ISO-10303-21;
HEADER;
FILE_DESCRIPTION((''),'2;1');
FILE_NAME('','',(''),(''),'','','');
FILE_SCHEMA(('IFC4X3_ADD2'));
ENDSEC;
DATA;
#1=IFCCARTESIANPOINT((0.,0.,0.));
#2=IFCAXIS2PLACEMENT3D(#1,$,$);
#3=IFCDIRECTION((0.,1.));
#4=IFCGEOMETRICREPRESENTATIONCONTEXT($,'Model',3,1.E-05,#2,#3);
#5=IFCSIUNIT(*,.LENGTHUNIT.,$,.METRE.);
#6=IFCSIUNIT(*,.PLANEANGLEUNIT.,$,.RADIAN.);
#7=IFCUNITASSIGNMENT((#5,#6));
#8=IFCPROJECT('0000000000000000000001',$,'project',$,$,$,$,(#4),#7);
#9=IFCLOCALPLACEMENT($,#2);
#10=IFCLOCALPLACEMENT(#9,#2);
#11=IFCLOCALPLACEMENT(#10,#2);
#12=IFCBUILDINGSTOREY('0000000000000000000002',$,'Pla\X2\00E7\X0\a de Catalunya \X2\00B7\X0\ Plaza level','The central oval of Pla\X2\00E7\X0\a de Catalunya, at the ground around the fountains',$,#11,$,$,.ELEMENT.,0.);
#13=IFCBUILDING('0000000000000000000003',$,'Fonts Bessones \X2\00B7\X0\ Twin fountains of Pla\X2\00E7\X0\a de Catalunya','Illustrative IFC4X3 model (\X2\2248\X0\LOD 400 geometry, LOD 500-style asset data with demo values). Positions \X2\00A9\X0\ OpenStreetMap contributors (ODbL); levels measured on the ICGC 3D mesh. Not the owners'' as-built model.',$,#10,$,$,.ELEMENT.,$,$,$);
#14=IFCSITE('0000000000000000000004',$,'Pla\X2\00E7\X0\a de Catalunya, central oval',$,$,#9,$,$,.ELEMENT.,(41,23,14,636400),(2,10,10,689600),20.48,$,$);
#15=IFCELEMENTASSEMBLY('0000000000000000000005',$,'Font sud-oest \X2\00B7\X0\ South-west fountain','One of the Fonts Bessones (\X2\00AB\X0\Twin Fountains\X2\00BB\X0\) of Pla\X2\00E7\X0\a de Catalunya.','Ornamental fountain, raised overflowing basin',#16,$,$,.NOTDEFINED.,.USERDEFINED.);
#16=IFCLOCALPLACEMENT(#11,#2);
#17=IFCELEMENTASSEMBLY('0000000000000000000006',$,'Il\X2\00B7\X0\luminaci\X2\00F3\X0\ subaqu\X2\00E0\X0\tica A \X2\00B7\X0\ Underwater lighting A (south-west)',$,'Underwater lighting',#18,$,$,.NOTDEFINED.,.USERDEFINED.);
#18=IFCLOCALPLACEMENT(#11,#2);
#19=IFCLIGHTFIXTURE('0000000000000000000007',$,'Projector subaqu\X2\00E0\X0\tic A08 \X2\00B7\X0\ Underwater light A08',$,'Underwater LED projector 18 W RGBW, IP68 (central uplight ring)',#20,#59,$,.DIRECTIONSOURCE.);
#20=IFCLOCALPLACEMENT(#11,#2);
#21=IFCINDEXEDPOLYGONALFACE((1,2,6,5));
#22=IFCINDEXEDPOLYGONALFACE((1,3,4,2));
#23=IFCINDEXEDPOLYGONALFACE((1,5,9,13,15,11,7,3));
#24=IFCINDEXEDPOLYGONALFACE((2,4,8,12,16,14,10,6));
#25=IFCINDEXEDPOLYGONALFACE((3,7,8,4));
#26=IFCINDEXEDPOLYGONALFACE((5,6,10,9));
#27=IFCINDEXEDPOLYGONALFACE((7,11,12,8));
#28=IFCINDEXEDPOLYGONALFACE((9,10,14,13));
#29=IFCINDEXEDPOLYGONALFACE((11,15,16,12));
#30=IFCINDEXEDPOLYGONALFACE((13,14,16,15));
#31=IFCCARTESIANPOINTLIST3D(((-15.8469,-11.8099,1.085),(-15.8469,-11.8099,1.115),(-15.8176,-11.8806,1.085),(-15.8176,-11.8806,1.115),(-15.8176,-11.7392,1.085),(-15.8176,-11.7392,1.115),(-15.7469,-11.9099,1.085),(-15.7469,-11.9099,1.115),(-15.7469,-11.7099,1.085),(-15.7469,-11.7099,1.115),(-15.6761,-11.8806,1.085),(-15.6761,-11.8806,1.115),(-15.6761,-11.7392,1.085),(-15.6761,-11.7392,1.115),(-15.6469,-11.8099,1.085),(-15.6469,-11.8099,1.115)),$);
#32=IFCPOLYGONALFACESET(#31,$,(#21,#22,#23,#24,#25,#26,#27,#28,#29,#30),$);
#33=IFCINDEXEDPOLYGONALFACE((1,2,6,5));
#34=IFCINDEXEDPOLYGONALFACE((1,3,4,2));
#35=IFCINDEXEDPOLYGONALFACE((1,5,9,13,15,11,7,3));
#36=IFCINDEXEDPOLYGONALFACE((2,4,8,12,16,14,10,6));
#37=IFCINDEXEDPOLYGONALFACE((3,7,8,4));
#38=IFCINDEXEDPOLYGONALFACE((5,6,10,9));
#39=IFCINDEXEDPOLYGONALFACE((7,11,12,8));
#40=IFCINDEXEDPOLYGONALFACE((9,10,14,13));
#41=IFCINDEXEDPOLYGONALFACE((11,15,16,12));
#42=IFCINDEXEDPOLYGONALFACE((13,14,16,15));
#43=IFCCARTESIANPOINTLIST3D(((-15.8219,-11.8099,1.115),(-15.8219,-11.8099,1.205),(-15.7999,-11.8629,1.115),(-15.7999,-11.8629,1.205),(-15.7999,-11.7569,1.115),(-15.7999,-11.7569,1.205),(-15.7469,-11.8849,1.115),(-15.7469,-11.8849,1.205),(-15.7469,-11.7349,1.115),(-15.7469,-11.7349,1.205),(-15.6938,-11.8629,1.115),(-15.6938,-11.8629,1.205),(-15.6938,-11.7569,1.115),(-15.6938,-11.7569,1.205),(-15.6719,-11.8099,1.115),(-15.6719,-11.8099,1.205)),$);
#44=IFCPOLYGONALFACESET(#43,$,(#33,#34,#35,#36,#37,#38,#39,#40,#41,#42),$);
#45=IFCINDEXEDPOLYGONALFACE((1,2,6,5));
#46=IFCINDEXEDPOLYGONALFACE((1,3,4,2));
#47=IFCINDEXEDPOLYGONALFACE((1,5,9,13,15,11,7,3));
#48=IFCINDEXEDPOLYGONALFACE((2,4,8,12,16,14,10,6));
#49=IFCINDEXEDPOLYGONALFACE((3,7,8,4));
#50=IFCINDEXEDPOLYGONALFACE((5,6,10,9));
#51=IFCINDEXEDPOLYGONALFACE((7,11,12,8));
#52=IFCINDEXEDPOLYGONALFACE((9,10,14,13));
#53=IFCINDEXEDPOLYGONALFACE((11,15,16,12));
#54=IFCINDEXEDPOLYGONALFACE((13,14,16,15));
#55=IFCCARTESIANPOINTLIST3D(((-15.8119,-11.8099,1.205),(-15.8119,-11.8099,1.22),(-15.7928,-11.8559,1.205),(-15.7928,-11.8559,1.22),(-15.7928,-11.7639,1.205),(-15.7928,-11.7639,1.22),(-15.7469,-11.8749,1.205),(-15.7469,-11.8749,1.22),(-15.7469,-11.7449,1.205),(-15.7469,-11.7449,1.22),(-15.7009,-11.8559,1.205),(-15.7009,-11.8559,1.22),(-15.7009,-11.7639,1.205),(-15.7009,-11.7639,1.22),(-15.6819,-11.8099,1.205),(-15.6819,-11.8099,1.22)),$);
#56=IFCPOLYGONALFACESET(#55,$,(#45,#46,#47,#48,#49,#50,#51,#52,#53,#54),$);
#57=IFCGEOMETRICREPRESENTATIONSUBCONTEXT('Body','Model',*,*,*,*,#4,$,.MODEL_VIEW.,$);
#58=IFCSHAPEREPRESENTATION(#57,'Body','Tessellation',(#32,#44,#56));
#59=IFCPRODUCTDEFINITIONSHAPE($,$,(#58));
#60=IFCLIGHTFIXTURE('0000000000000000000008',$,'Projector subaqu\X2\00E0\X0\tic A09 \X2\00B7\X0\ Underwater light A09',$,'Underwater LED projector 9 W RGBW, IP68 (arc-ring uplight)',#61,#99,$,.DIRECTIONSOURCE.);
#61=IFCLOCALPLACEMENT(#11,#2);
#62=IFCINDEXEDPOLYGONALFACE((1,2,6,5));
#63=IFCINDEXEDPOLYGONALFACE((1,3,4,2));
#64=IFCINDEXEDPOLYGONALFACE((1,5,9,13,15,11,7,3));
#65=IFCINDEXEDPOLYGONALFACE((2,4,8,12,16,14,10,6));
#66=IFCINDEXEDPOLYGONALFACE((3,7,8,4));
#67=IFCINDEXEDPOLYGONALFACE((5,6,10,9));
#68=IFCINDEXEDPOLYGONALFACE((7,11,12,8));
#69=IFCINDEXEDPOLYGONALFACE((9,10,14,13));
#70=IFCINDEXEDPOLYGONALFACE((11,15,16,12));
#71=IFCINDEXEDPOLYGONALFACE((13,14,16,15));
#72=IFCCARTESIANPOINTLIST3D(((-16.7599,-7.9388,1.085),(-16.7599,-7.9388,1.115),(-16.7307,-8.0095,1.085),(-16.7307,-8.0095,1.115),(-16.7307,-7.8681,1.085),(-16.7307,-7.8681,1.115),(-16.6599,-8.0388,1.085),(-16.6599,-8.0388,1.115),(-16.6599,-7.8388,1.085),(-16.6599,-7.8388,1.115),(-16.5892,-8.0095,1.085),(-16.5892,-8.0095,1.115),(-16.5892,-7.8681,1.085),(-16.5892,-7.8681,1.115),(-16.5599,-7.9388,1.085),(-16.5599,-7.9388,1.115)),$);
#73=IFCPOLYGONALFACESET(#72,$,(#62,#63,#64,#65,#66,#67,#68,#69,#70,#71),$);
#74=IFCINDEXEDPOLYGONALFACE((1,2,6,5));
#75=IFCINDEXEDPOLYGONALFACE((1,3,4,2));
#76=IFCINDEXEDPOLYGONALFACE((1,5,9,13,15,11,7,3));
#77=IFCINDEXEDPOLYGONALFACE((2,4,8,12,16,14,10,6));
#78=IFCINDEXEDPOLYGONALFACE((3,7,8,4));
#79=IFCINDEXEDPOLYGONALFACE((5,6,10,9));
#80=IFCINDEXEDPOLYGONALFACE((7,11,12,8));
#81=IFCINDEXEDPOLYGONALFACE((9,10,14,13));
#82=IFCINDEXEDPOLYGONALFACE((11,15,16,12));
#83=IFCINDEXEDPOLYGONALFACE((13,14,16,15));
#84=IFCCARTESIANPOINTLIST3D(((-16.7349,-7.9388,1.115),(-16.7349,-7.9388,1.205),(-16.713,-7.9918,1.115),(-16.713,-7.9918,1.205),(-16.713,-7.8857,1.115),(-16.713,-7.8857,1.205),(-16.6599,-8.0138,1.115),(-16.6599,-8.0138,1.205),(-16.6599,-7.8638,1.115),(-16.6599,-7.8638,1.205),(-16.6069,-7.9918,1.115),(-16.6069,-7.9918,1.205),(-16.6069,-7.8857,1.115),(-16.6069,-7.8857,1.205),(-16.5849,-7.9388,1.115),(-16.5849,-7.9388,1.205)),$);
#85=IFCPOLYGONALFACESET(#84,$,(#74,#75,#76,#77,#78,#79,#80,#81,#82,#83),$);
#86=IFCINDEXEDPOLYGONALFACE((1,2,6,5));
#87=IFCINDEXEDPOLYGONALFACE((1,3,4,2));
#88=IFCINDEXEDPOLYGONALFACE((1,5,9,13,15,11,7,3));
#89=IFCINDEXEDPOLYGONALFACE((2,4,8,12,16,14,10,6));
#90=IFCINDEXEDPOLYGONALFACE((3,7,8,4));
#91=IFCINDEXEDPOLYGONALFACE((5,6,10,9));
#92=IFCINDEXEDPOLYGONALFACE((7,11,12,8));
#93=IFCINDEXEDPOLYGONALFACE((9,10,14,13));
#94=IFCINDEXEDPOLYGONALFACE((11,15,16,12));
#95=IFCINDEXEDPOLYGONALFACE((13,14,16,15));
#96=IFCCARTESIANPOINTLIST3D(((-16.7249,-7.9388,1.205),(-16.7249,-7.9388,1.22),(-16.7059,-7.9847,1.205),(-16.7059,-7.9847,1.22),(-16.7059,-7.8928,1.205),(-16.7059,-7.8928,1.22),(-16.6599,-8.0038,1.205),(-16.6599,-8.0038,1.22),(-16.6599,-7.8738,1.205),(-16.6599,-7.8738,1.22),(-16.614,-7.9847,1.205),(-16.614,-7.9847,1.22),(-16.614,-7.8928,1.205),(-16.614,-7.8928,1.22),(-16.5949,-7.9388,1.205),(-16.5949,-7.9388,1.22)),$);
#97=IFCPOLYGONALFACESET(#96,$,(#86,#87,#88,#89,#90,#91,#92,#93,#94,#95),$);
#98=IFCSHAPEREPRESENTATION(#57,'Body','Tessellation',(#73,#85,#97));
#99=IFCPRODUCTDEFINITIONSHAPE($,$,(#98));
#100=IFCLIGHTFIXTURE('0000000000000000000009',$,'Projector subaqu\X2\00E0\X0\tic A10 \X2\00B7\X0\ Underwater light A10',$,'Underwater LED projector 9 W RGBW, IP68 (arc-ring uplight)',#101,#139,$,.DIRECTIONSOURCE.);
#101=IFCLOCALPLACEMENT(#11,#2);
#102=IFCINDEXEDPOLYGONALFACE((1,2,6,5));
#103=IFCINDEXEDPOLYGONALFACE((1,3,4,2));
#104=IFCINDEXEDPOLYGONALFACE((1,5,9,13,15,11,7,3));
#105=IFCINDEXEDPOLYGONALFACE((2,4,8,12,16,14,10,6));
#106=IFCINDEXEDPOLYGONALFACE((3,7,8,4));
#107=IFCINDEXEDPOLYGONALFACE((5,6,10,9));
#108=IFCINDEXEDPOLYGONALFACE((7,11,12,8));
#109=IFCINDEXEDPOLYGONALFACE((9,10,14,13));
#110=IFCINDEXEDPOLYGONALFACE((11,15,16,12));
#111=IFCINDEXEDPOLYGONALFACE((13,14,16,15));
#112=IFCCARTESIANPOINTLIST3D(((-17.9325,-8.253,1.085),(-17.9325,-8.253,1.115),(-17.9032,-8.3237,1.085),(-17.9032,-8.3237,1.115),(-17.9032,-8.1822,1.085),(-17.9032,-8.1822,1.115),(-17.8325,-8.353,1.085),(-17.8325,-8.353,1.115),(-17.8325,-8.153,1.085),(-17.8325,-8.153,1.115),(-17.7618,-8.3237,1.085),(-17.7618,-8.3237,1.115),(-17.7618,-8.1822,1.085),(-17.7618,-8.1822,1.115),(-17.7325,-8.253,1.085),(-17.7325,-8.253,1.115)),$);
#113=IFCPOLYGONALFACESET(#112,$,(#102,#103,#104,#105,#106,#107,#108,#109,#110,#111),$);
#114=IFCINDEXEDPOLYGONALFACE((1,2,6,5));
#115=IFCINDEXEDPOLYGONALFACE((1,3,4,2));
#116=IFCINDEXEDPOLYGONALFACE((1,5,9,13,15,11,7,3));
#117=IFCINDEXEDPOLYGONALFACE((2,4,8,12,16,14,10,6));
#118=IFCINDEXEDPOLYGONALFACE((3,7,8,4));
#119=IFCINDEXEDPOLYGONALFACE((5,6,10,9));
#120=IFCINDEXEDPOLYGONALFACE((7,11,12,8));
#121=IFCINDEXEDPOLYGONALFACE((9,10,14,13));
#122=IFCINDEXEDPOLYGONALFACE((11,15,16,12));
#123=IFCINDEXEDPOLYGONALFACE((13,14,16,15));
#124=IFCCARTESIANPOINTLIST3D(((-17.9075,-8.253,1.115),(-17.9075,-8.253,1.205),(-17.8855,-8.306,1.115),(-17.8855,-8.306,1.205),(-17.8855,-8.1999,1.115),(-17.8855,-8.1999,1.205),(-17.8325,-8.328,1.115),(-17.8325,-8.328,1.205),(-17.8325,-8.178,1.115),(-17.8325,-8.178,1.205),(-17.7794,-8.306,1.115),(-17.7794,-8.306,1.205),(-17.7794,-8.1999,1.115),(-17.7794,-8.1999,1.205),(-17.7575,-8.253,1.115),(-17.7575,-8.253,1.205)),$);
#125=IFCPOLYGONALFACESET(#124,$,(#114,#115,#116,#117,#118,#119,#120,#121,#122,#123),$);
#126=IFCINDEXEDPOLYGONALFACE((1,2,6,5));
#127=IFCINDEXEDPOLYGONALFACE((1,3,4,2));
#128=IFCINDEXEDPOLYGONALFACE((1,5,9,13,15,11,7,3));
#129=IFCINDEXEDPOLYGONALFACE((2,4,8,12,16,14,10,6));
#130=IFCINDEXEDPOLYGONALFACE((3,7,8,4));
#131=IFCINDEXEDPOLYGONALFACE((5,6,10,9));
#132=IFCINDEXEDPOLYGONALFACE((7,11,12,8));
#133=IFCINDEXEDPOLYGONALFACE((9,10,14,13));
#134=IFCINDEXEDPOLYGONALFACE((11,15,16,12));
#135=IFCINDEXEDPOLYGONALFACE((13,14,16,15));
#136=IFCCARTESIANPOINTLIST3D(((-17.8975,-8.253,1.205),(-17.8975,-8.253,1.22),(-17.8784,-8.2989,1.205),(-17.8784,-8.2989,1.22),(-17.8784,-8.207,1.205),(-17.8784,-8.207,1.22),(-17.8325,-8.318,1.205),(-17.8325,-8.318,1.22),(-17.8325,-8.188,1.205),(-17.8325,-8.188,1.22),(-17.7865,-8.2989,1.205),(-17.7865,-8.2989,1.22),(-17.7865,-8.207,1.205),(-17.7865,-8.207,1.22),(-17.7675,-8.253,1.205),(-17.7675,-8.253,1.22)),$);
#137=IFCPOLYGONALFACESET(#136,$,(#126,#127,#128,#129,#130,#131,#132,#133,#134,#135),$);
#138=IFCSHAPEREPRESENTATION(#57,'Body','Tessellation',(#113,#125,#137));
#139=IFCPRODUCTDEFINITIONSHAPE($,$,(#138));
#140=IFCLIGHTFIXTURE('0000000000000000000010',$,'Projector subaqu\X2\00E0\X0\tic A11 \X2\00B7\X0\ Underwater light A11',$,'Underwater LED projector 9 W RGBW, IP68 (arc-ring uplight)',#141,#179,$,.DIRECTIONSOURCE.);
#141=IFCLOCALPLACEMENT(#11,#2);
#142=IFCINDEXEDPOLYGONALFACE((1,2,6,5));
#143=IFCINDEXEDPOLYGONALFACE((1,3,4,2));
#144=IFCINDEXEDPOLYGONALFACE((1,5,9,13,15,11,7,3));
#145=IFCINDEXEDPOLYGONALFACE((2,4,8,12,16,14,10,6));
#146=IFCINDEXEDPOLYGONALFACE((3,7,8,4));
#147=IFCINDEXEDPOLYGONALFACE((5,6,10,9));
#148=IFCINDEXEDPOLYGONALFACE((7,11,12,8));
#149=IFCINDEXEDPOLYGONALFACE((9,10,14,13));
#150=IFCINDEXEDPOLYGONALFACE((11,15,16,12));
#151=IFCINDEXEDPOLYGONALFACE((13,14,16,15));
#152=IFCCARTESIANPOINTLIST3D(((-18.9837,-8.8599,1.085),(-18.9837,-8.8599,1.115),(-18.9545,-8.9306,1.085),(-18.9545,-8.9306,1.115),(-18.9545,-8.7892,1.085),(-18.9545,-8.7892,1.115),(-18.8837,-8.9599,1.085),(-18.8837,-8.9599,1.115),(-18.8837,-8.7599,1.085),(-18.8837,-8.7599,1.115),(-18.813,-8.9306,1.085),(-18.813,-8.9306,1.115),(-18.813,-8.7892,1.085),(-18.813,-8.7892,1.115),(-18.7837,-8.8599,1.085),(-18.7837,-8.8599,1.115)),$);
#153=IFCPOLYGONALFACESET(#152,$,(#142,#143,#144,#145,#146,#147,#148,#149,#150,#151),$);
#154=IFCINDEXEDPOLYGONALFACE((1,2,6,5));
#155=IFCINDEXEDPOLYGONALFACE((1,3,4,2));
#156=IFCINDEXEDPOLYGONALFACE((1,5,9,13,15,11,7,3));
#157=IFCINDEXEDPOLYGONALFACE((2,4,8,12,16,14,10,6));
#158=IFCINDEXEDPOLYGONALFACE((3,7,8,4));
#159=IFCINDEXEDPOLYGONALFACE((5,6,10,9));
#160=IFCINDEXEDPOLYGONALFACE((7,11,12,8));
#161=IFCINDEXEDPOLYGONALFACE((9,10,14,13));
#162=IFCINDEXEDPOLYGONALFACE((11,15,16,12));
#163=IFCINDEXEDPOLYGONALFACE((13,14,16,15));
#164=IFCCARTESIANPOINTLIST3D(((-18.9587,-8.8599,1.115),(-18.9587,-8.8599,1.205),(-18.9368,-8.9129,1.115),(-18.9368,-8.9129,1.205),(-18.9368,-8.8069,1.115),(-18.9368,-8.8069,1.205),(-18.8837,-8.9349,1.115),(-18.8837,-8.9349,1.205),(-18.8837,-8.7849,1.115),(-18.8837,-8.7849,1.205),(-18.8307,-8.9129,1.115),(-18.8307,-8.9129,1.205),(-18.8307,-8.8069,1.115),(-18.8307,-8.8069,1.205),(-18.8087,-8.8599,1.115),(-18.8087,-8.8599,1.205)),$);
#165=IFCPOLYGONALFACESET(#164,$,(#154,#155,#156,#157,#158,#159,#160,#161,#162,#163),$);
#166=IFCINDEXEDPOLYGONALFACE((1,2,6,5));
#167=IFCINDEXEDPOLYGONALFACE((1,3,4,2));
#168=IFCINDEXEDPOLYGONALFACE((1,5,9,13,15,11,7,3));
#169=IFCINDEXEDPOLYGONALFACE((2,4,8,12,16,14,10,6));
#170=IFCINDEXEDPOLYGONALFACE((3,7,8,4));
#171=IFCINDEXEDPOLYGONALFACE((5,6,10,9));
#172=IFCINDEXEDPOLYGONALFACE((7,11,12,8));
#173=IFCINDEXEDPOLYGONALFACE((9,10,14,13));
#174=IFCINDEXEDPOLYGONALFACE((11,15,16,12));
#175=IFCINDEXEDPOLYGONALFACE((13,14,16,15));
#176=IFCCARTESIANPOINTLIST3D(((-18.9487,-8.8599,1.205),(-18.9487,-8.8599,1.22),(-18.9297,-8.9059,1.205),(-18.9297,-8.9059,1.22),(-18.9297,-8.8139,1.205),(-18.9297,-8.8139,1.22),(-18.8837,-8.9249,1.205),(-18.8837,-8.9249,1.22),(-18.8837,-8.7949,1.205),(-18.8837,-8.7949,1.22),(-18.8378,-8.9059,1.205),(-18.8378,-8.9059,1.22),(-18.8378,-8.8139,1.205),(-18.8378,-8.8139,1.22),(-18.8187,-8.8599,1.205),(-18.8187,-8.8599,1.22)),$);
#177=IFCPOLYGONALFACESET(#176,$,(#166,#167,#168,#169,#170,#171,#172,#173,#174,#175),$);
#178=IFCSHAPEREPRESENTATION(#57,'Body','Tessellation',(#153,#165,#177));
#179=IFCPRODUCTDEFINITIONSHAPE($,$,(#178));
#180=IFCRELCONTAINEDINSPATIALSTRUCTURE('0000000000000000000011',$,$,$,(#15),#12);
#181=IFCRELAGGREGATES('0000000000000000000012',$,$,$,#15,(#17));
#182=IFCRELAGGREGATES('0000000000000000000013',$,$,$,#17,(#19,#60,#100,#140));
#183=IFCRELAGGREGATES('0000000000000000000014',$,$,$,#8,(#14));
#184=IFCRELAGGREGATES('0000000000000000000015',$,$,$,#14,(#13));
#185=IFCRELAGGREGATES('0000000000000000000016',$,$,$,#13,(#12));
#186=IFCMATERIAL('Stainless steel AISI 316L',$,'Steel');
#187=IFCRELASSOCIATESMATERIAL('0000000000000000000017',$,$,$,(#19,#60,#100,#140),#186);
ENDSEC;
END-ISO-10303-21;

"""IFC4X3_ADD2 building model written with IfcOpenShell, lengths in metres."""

from ifc_helpers import new_model, si_unit, direction, frame, origin, place, context, subcontext, project, spatial, polyline, outline, extrude, material, element, aggregate, save


model = new_model("IFC4X3_ADD2")

# Units and contexts
model_context = context("Model", 3, precision=1e-05, world=origin(), true_north=direction((0.0, 1.0)))
body_context = subcontext(model_context, "Body", "Model", "MODEL_VIEW")
ifc_project = project(units=[si_unit("LENGTHUNIT", "METRE"), si_unit("PLANEANGLEUNIT", "RADIAN")], contexts=[model_context])

# Site, building, storey
site_placement = place(None, origin())
site = spatial("IfcSite", under=ifc_project, at=site_placement, Name="Plaça de Catalunya, central oval", CompositionType="ELEMENT", RefLatitude=(41, 23, 14, 636400), RefLongitude=(2, 10, 10, 689600), RefElevation=20.48)
building_placement = place(site_placement, origin())
building = spatial("IfcBuilding", under=site, at=building_placement, Name="Fonts Bessones · Twin fountains of Plaça de Catalunya", Description="Illustrative IFC4X3 model (≈LOD 400 geometry, LOD 500-style asset data with demo values). Positions © OpenStreetMap contributors (ODbL); levels measured on the ICGC 3D mesh. Not the owners' as-built model.", CompositionType="ELEMENT")
storey_placement = place(building_placement, origin())
storey = spatial("IfcBuildingStorey", under=building, at=storey_placement, Name="Plaça de Catalunya · Plaza level", Description="The central oval of Plaça de Catalunya, at the ground around the fountains", CompositionType="ELEMENT", Elevation=0.0)

# Element assemblies, light fixtures
assembly_1_placement = place(building_placement, origin())
assembly_1 = element("IfcElementAssembly", 1, at=assembly_1_placement, inside=storey, Name="Font sud-oest · South-west fountain", Description="One of the Fonts Bessones («Twin Fountains») of Plaça de Catalunya.", ObjectType="Ornamental fountain, raised overflowing basin", AssemblyPlace="NOTDEFINED", PredefinedType="USERDEFINED")
assembly_2_placement = place(building_placement, origin())
assembly_2 = element("IfcElementAssembly", 2, at=assembly_2_placement, Name="Il·luminació subaquàtica A · Underwater lighting A (south-west)", ObjectType="Underwater lighting", AssemblyPlace="NOTDEFINED", PredefinedType="USERDEFINED")
aggregate(assembly_1, [assembly_2])
ifc_material_1 = material(Name="Stainless steel AISI 316L", Category="Steel")
light_fixture_1_placement = place(building_placement, origin())
light_fixture_1 = element("IfcLightFixture", 3, at=light_fixture_1_placement, material=ifc_material_1, Name="Projector subaquàtic A08 · Underwater light A08", ObjectType="Underwater LED projector 18 W RGBW, IP68 (central uplight ring)", PredefinedType="DIRECTIONSOURCE", context=body_context, shape_type="SweptSolid", body=[
    extrude(outline(polyline([(-15.6469, -11.8099), (-15.6761, -11.7392), (-15.7469, -11.7099), (-15.8176, -11.7392), (-15.8469, -11.8099), (-15.8176, -11.8806), (-15.7469, -11.9099), (-15.6761, -11.8806), (-15.6469, -11.8099)])), frame((0.0, 0.0, 1.085)), (0.0, 0.0, 1.0), 0.03),
    extrude(outline(polyline([(-15.6719, -11.8099), (-15.6938, -11.7569), (-15.7469, -11.7349), (-15.7999, -11.7569), (-15.8219, -11.8099), (-15.7999, -11.8629), (-15.7469, -11.8849), (-15.6938, -11.8629), (-15.6719, -11.8099)])), frame((0.0, 0.0, 1.115)), (0.0, 0.0, 1.0), 0.09),
    extrude(outline(polyline([(-15.6819, -11.8099), (-15.7009, -11.7639), (-15.7469, -11.7449), (-15.7928, -11.7639), (-15.8119, -11.8099), (-15.7928, -11.8559), (-15.7469, -11.8749), (-15.7009, -11.8559), (-15.6819, -11.8099)])), frame((0.0, 0.0, 1.205)), (0.0, 0.0, 1.0), 0.015),
])
light_fixture_2_placement = place(building_placement, origin())
light_fixture_2 = element("IfcLightFixture", 4, at=light_fixture_2_placement, material=ifc_material_1, Name="Projector subaquàtic A09 · Underwater light A09", ObjectType="Underwater LED projector 9 W RGBW, IP68 (arc-ring uplight)", PredefinedType="DIRECTIONSOURCE", context=body_context, shape_type="SweptSolid", body=[
    extrude(outline(polyline([(-16.5599, -7.9388), (-16.5892, -7.8681), (-16.6599, -7.8388), (-16.7307, -7.8681), (-16.7599, -7.9388), (-16.7307, -8.0095), (-16.6599, -8.0388), (-16.5892, -8.0095), (-16.5599, -7.9388)])), frame((0.0, 0.0, 1.085)), (0.0, 0.0, 1.0), 0.03),
    extrude(outline(polyline([(-16.5849, -7.9388), (-16.6069, -7.8857), (-16.6599, -7.8638), (-16.713, -7.8857), (-16.7349, -7.9388), (-16.713, -7.9918), (-16.6599, -8.0138), (-16.6069, -7.9918), (-16.5849, -7.9388)])), frame((0.0, 0.0, 1.115)), (0.0, 0.0, 1.0), 0.09),
    extrude(outline(polyline([(-16.5949, -7.9388), (-16.614, -7.8928), (-16.6599, -7.8738), (-16.7059, -7.8928), (-16.7249, -7.9388), (-16.7059, -7.9847), (-16.6599, -8.0038), (-16.614, -7.9847), (-16.5949, -7.9388)])), frame((0.0, 0.0, 1.205)), (0.0, 0.0, 1.0), 0.015),
])
light_fixture_3_placement = place(building_placement, origin())
light_fixture_3 = element("IfcLightFixture", 5, at=light_fixture_3_placement, material=ifc_material_1, Name="Projector subaquàtic A10 · Underwater light A10", ObjectType="Underwater LED projector 9 W RGBW, IP68 (arc-ring uplight)", PredefinedType="DIRECTIONSOURCE", context=body_context, shape_type="SweptSolid", body=[
    extrude(outline(polyline([(-17.7325, -8.253), (-17.7618, -8.1822), (-17.8325, -8.153), (-17.9032, -8.1822), (-17.9325, -8.253), (-17.9032, -8.3237), (-17.8325, -8.353), (-17.7618, -8.3237), (-17.7325, -8.253)])), frame((0.0, 0.0, 1.085)), (0.0, 0.0, 1.0), 0.03),
    extrude(outline(polyline([(-17.7575, -8.253), (-17.7794, -8.1999), (-17.8325, -8.178), (-17.8855, -8.1999), (-17.9075, -8.253), (-17.8855, -8.306), (-17.8325, -8.328), (-17.7794, -8.306), (-17.7575, -8.253)])), frame((0.0, 0.0, 1.115)), (0.0, 0.0, 1.0), 0.09),
    extrude(outline(polyline([(-17.7675, -8.253), (-17.7865, -8.207), (-17.8325, -8.188), (-17.8784, -8.207), (-17.8975, -8.253), (-17.8784, -8.2989), (-17.8325, -8.318), (-17.7865, -8.2989), (-17.7675, -8.253)])), frame((0.0, 0.0, 1.205)), (0.0, 0.0, 1.0), 0.015),
])
light_fixture_4_placement = place(building_placement, origin())
light_fixture_4 = element("IfcLightFixture", 6, at=light_fixture_4_placement, material=ifc_material_1, Name="Projector subaquàtic A11 · Underwater light A11", ObjectType="Underwater LED projector 9 W RGBW, IP68 (arc-ring uplight)", PredefinedType="DIRECTIONSOURCE", context=body_context, shape_type="SweptSolid", body=[
    extrude(outline(polyline([(-18.7837, -8.8599), (-18.813, -8.7892), (-18.8837, -8.7599), (-18.9545, -8.7892), (-18.9837, -8.8599), (-18.9545, -8.9306), (-18.8837, -8.9599), (-18.813, -8.9306), (-18.7837, -8.8599)])), frame((0.0, 0.0, 1.085)), (0.0, 0.0, 1.0), 0.03),
    extrude(outline(polyline([(-18.8087, -8.8599), (-18.8307, -8.8069), (-18.8837, -8.7849), (-18.9368, -8.8069), (-18.9587, -8.8599), (-18.9368, -8.9129), (-18.8837, -8.9349), (-18.8307, -8.9129), (-18.8087, -8.8599)])), frame((0.0, 0.0, 1.115)), (0.0, 0.0, 1.0), 0.09),
    extrude(outline(polyline([(-18.8187, -8.8599), (-18.8378, -8.8139), (-18.8837, -8.7949), (-18.9297, -8.8139), (-18.9487, -8.8599), (-18.9297, -8.9059), (-18.8837, -8.9249), (-18.8378, -8.9059), (-18.8187, -8.8599)])), frame((0.0, 0.0, 1.205)), (0.0, 0.0, 1.0), 0.015),
])
aggregate(assembly_2, [light_fixture_1, light_fixture_2, light_fixture_3, light_fixture_4])

save(model, "model.ifc")
